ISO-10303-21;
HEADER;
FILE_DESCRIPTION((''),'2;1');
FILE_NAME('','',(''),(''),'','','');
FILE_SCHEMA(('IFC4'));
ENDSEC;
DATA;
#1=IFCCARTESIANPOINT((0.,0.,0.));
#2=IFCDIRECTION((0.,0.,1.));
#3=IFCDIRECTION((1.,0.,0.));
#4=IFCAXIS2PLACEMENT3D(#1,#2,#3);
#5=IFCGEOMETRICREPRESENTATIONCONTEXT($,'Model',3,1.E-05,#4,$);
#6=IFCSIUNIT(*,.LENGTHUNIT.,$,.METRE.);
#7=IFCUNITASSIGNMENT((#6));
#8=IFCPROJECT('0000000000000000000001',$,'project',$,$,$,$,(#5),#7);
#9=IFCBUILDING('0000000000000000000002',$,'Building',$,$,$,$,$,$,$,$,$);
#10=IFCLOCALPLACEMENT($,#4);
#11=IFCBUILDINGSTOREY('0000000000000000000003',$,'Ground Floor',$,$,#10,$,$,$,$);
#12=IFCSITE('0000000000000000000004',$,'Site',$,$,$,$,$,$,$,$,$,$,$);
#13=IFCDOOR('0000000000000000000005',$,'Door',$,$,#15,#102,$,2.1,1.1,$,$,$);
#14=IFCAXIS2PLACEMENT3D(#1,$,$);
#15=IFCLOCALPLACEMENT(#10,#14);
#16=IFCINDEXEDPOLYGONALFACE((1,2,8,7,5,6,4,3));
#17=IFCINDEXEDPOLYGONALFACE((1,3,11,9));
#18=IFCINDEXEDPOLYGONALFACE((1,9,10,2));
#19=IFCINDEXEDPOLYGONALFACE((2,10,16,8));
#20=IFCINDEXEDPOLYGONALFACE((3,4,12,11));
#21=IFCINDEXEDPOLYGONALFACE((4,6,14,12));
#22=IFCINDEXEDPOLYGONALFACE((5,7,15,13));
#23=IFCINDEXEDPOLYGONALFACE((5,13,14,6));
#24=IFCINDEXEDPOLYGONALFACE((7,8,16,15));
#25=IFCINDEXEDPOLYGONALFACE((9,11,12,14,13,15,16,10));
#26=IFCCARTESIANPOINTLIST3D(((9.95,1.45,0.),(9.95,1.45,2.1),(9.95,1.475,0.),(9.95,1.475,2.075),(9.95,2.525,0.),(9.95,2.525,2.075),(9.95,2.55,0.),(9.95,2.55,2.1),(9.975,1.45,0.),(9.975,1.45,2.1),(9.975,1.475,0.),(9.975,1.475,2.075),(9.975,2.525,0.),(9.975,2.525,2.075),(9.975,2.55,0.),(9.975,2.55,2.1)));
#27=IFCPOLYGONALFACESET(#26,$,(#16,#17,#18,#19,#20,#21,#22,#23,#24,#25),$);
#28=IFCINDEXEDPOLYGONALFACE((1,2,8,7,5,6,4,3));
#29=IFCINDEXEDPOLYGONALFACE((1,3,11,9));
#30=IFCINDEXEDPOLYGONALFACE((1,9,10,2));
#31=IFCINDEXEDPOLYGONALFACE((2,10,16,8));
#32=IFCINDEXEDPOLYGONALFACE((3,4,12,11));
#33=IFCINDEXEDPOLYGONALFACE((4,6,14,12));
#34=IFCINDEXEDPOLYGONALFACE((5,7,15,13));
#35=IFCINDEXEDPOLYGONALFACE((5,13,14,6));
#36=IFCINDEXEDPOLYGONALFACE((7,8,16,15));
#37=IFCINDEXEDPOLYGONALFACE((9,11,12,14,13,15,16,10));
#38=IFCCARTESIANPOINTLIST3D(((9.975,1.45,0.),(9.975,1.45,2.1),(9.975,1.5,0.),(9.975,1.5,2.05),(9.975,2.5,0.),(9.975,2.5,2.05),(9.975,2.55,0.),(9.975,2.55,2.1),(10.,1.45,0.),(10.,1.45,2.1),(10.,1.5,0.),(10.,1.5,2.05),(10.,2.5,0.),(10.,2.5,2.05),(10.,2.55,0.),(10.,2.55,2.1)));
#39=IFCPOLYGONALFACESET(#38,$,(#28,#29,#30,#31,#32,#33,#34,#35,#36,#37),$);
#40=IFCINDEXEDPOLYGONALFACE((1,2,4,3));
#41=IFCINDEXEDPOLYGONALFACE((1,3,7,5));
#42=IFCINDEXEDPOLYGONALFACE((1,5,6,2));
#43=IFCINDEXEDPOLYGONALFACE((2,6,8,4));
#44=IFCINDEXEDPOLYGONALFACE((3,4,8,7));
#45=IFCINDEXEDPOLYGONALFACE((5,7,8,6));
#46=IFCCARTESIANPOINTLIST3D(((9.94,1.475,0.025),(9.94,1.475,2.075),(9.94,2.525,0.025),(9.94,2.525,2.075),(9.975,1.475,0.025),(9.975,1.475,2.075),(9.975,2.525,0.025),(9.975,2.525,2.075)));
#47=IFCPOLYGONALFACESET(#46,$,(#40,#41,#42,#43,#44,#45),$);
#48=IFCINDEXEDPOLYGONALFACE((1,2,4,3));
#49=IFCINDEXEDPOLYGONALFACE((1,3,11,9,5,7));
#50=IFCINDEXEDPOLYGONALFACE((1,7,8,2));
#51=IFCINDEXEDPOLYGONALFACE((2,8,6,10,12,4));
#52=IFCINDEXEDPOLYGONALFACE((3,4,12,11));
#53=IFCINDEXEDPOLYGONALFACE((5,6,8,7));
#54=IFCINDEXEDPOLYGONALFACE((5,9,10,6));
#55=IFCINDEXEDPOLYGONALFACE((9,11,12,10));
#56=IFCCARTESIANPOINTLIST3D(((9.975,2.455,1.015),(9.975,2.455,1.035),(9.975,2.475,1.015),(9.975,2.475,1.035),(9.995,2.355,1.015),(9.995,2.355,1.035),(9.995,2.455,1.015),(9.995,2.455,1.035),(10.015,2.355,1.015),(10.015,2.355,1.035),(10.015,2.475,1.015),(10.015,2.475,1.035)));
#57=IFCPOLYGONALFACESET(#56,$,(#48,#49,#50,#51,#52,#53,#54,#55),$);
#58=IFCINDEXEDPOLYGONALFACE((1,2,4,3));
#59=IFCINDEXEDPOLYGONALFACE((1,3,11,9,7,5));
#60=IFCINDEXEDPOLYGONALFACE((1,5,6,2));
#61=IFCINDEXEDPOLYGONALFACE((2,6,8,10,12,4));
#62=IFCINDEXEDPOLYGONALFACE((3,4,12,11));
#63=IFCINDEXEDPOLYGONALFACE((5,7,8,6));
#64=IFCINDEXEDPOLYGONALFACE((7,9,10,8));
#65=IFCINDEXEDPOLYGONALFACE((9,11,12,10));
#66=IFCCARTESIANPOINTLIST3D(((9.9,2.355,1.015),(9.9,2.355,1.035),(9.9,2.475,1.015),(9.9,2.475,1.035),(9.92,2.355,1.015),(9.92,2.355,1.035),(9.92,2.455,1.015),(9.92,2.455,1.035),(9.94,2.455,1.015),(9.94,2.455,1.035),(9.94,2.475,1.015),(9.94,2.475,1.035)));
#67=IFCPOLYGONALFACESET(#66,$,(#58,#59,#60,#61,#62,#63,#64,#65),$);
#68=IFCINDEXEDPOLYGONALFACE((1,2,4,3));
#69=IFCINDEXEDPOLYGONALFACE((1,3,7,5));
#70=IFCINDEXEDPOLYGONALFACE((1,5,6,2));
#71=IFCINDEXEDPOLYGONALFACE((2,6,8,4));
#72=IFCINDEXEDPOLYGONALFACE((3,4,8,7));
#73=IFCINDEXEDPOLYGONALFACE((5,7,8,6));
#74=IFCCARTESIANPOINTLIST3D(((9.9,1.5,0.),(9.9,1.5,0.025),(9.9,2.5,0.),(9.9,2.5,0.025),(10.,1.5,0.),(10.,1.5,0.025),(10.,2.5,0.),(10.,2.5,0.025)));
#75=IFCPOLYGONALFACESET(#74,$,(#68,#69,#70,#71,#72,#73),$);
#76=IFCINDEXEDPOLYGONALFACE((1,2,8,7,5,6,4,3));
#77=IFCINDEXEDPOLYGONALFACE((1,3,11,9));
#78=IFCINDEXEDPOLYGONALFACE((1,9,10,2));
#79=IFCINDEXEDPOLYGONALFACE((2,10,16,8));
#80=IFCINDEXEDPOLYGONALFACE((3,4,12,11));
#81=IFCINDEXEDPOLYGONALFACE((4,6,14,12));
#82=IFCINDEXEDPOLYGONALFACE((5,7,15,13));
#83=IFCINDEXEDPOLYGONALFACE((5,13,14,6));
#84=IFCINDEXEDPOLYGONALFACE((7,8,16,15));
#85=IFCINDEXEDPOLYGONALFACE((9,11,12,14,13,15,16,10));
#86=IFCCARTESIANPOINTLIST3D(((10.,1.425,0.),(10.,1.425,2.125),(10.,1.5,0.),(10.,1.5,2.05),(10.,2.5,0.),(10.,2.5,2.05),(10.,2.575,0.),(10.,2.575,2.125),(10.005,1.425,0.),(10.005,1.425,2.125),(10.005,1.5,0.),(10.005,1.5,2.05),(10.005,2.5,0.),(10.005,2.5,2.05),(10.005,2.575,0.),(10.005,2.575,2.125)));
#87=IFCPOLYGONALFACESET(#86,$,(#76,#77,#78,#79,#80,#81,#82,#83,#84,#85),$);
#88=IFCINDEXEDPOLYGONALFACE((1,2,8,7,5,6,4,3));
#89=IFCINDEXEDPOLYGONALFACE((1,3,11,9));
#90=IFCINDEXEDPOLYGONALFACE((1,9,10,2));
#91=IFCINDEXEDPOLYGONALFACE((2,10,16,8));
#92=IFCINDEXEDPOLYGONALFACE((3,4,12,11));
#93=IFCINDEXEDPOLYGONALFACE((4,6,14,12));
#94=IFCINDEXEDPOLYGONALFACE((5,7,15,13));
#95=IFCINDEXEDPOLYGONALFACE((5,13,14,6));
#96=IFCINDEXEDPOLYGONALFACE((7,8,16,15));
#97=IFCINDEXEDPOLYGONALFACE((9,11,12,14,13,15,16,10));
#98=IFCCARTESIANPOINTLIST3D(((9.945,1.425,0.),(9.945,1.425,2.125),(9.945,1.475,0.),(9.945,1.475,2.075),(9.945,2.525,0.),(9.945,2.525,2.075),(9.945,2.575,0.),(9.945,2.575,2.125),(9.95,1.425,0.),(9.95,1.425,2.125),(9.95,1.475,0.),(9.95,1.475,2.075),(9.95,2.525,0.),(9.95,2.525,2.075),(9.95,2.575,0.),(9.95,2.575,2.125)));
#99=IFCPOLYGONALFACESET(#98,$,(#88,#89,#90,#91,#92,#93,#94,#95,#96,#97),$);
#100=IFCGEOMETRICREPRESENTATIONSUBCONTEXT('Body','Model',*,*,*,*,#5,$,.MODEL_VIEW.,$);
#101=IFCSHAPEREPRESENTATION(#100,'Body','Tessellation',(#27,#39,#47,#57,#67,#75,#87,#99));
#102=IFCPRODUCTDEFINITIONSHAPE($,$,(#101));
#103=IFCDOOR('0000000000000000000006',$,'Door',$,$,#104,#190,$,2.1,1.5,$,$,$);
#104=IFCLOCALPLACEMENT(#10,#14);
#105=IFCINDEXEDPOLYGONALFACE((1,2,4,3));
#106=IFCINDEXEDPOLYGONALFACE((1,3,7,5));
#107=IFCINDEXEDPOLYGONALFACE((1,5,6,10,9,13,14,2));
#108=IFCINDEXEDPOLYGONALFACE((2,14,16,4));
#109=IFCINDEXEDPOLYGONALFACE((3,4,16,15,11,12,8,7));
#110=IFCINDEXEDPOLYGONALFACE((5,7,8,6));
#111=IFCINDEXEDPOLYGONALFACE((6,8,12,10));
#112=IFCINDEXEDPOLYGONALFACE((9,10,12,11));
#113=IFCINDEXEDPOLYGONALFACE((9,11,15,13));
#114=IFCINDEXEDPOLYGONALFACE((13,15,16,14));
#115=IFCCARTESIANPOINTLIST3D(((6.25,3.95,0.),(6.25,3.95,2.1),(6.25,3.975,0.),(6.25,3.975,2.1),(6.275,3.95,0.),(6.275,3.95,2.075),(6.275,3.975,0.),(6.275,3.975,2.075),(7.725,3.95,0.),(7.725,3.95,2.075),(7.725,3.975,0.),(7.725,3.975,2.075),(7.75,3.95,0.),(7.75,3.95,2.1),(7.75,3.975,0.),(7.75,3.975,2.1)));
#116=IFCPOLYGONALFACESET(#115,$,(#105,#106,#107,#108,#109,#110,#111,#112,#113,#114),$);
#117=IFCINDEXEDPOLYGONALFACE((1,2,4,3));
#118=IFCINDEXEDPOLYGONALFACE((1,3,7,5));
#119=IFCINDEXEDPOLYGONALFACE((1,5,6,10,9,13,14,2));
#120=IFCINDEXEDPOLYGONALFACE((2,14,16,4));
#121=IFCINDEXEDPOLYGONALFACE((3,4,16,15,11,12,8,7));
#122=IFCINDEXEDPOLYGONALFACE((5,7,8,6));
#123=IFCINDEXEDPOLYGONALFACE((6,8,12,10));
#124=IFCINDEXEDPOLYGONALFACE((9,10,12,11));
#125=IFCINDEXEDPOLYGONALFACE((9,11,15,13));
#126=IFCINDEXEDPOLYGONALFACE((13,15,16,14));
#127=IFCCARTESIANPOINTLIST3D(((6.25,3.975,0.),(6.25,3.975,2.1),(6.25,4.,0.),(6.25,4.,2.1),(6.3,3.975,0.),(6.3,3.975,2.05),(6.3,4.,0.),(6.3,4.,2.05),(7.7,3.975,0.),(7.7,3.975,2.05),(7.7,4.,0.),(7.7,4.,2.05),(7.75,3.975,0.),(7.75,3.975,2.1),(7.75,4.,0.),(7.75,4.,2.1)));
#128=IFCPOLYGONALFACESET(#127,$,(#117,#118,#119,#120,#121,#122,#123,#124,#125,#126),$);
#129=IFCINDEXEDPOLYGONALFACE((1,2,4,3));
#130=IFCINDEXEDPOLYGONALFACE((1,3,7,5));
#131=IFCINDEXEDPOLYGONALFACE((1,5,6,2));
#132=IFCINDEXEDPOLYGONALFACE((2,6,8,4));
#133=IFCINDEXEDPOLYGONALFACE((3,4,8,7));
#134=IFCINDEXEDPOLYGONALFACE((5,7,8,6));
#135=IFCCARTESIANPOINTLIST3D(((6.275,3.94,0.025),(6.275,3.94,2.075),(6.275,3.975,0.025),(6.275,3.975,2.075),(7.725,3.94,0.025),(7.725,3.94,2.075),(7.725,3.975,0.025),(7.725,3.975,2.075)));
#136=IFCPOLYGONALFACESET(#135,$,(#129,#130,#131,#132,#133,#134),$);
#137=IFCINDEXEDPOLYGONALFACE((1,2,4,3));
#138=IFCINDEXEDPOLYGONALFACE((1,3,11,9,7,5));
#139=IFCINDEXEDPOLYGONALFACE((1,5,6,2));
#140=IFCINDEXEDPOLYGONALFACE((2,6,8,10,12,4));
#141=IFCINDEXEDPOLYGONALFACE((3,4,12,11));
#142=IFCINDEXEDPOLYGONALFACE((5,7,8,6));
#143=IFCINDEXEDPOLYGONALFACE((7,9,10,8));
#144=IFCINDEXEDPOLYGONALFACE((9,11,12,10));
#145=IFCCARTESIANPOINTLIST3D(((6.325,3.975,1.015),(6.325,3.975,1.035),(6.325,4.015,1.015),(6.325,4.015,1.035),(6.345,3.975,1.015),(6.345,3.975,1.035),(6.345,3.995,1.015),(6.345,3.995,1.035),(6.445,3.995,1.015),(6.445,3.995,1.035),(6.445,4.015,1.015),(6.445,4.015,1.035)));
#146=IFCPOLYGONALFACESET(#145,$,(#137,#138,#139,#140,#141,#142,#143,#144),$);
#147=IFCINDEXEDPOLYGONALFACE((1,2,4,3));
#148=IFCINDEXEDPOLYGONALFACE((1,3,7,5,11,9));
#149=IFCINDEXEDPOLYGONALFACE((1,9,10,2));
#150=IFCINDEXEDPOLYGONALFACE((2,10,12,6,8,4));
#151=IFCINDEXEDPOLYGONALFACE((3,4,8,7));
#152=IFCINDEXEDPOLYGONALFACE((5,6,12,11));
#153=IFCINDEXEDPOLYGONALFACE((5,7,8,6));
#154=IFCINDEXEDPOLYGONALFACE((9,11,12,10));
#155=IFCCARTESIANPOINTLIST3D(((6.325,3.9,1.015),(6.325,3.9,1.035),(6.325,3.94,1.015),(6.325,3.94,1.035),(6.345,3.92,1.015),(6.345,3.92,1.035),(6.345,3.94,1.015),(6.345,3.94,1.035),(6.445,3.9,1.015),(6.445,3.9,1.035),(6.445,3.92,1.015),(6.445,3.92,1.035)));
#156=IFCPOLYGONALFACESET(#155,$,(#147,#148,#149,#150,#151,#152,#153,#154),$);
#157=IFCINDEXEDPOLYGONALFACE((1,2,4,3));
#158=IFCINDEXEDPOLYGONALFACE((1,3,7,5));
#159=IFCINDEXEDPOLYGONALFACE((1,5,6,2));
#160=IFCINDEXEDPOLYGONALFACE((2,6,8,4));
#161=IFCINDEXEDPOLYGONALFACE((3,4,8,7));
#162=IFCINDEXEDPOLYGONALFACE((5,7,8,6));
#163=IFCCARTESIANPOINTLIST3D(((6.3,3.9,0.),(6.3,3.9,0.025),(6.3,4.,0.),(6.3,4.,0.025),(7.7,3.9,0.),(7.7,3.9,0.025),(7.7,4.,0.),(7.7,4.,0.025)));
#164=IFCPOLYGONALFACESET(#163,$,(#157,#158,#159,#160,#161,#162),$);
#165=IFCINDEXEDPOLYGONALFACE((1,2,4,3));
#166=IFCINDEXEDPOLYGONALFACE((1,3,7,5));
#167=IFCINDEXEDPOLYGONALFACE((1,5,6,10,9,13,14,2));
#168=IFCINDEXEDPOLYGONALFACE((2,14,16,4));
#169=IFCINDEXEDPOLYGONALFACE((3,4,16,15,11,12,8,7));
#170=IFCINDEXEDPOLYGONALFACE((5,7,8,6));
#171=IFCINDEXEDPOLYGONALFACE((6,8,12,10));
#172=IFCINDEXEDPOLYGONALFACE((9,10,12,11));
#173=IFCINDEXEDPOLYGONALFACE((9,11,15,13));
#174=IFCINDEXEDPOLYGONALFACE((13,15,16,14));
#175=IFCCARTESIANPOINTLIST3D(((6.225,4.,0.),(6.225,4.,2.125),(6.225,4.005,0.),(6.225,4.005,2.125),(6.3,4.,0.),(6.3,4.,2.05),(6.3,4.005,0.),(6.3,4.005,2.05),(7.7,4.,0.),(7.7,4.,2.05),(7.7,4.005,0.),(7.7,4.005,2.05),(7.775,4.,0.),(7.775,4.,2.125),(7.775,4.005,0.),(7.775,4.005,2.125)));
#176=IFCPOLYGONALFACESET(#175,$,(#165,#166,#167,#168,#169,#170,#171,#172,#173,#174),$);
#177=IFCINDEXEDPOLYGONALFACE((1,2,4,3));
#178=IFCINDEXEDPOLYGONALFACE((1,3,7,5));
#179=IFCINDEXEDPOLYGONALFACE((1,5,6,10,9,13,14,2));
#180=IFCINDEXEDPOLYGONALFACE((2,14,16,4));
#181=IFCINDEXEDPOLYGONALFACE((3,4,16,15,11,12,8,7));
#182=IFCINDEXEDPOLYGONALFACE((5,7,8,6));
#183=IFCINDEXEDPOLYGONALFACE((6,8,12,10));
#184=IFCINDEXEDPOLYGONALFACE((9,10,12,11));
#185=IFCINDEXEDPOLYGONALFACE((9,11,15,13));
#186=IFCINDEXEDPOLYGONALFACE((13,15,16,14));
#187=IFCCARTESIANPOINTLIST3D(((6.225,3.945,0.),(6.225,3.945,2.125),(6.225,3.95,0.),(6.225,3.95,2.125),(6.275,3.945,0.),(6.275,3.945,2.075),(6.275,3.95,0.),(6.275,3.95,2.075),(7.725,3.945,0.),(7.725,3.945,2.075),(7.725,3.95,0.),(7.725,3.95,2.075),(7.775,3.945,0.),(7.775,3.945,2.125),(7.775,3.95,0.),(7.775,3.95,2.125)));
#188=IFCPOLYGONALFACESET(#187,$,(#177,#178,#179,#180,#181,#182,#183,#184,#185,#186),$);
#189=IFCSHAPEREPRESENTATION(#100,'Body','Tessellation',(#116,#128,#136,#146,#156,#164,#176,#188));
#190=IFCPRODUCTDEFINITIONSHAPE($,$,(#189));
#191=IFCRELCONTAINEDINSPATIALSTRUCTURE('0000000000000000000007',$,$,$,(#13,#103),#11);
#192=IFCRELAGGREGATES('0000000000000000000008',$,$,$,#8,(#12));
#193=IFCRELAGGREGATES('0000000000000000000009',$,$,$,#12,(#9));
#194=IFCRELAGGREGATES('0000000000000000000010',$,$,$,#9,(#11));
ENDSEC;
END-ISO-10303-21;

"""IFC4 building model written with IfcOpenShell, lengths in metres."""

from ifc_helpers import new_model, si_unit, frame, origin_with_axes, place, context, subcontext, project, spatial, line, indexed_curve, outline, extrude, element, save


model = new_model("IFC4")

# Units and contexts
model_context = context("Model", 3, precision=1e-05, world=origin_with_axes())
body_context = subcontext(model_context, "Body", "Model", "MODEL_VIEW")
ifc_project = project(units=[si_unit("LENGTHUNIT", "METRE")], contexts=[model_context])

# Site, building, storey
site = spatial("IfcSite", under=ifc_project, Name="Site")
building = spatial("IfcBuilding", under=site, Name="Building")
storey_placement = place(None, origin_with_axes())
storey = spatial("IfcBuildingStorey", under=building, at=storey_placement, Name="Ground Floor")

# Doors
door_1_placement = place(storey_placement, frame((10.0, 1.45, 0.0), z_axis=(0.0, 0.0, 1.0), x_axis=(0.0, 1.0, 0.0)))
element("IfcDoor", 1, at=door_1_placement, inside=storey, Name="Door", OverallHeight=2.1, OverallWidth=1.1, context=body_context, shape_type="SweptSolid", body=[
    extrude(outline(indexed_curve([(0.0, 0.0), (0.0, 2.1), (1.1, 2.1), (1.1, 0.0), (1.075, 0.0), (1.075, 2.075), (0.025, 2.075), (0.025, 0.0)], segments=[line(1, 2, 3, 4, 5, 6, 7, 8, 1)])), frame((0.0, 0.025, 0.0), z_axis=(0.0, -1.0, 0.0), x_axis=(1.0, 0.0, 0.0)), (0.0, 0.0, -1.0), 0.025),
    extrude(outline(indexed_curve([(0.0, 0.0), (0.0, 2.1), (1.1, 2.1), (1.1, 0.0), (1.05, 0.0), (1.05, 2.05), (0.05, 2.05), (0.05, 0.0)], segments=[line(1, 2, 3, 4, 5, 6, 7, 8, 1)])), frame((0.0, 0.0, 0.0), z_axis=(0.0, -1.0, 0.0), x_axis=(1.0, 0.0, 0.0)), (0.0, 0.0, -1.0), 0.025),
    extrude(outline(indexed_curve([(0.0, 0.0), (1.05, 0.0), (1.05, 0.035), (0.0, 0.035)], segments=[line(1, 2, 3, 4, 1)])), frame((0.025, 0.025, 0.025), z_axis=(0.0, 0.0, 1.0), x_axis=(1.0, 0.0, 0.0)), (0.0, 0.0, 1.0), 2.05),
    extrude(outline(indexed_curve([(0.0, 0.0), (0.0, -0.04), (-0.12, -0.04), (-0.12, -0.02), (-0.02, -0.02), (-0.02, 0.0)], segments=[line(1, 2, 3, 4, 5, 6, 1)])), frame((1.025, 0.025, 1.015), z_axis=(0.0, 0.0, 1.0), x_axis=(1.0, 0.0, 0.0)), (0.0, 0.0, 1.0), 0.02),
    extrude(outline(indexed_curve([(0.0, 0.0), (0.0, 0.04), (-0.12, 0.04), (-0.12, 0.02), (-0.02, 0.02), (-0.02, 0.0)], segments=[line(1, 2, 3, 4, 5, 6, 1)])), frame((1.025, 0.06, 1.015), z_axis=(0.0, 0.0, 1.0), x_axis=(1.0, 0.0, 0.0)), (0.0, 0.0, 1.0), 0.02),
    extrude(outline(indexed_curve([(0.0, 0.0), (1.0, 0.0), (1.0, 0.1), (0.0, 0.1)], segments=[line(1, 2, 3, 4, 1)])), frame((0.05, 0.0, 0.0), z_axis=(0.0, 0.0, 1.0), x_axis=(1.0, 0.0, 0.0)), (0.0, 0.0, 1.0), 0.025),
    extrude(outline(indexed_curve([(0.0, 0.0), (0.0, 2.125), (1.15, 2.125), (1.15, 0.0), (1.075, 0.0), (1.075, 2.05), (0.075, 2.05), (0.075, 0.0)], segments=[line(1, 2, 3, 4, 5, 6, 7, 8, 1)])), frame((-0.025, -0.005, 0.0), z_axis=(0.0, -1.0, 0.0), x_axis=(1.0, 0.0, 0.0)), (0.0, 0.0, -1.0), 0.005),
    extrude(outline(indexed_curve([(0.0, 0.0), (0.0, 2.125), (1.15, 2.125), (1.15, 0.0), (1.1, 0.0), (1.1, 2.075), (0.05, 2.075), (0.05, 0.0)], segments=[line(1, 2, 3, 4, 5, 6, 7, 8, 1)])), frame((-0.025, 0.05, 0.0), z_axis=(0.0, -1.0, 0.0), x_axis=(1.0, 0.0, 0.0)), (0.0, 0.0, -1.0), 0.005),
])
door_2_placement = place(storey_placement, frame((7.75, 4.0, 0.0), z_axis=(0.0, 0.0, 1.0), x_axis=(-1.0, 0.0, 0.0)))
element("IfcDoor", 2, at=door_2_placement, inside=storey, Name="Door", OverallHeight=2.1, OverallWidth=1.5, context=body_context, shape_type="SweptSolid", body=[
    extrude(outline(indexed_curve([(0.0, 0.0), (0.0, 2.1), (1.5, 2.1), (1.5, 0.0), (1.475, 0.0), (1.475, 2.075), (0.025, 2.075), (0.025, 0.0)], segments=[line(1, 2, 3, 4, 5, 6, 7, 8, 1)])), frame((0.0, 0.025, 0.0), z_axis=(0.0, -1.0, 0.0), x_axis=(1.0, 0.0, 0.0)), (0.0, 0.0, -1.0), 0.025),
    extrude(outline(indexed_curve([(0.0, 0.0), (0.0, 2.1), (1.5, 2.1), (1.5, 0.0), (1.45, 0.0), (1.45, 2.05), (0.05, 2.05), (0.05, 0.0)], segments=[line(1, 2, 3, 4, 5, 6, 7, 8, 1)])), frame((0.0, 0.0, 0.0), z_axis=(0.0, -1.0, 0.0), x_axis=(1.0, 0.0, 0.0)), (0.0, 0.0, -1.0), 0.025),
    extrude(outline(indexed_curve([(0.0, 0.0), (1.45, 0.0), (1.45, 0.035), (0.0, 0.035)], segments=[line(1, 2, 3, 4, 1)])), frame((0.025, 0.025, 0.025), z_axis=(0.0, 0.0, 1.0), x_axis=(1.0, 0.0, 0.0)), (0.0, 0.0, 1.0), 2.05),
    extrude(outline(indexed_curve([(0.0, 0.0), (0.0, -0.04), (-0.12, -0.04), (-0.12, -0.02), (-0.02, -0.02), (-0.02, 0.0)], segments=[line(1, 2, 3, 4, 5, 6, 1)])), frame((1.425, 0.025, 1.015), z_axis=(0.0, 0.0, 1.0), x_axis=(1.0, 0.0, 0.0)), (0.0, 0.0, 1.0), 0.02),
    extrude(outline(indexed_curve([(0.0, 0.0), (0.0, 0.04), (-0.12, 0.04), (-0.12, 0.02), (-0.02, 0.02), (-0.02, 0.0)], segments=[line(1, 2, 3, 4, 5, 6, 1)])), frame((1.425, 0.06, 1.015), z_axis=(0.0, 0.0, 1.0), x_axis=(1.0, 0.0, 0.0)), (0.0, 0.0, 1.0), 0.02),
    extrude(outline(indexed_curve([(0.0, 0.0), (1.4, 0.0), (1.4, 0.1), (0.0, 0.1)], segments=[line(1, 2, 3, 4, 1)])), frame((0.05, 0.0, 0.0), z_axis=(0.0, 0.0, 1.0), x_axis=(1.0, 0.0, 0.0)), (0.0, 0.0, 1.0), 0.025),
    extrude(outline(indexed_curve([(0.0, 0.0), (0.0, 2.125), (1.55, 2.125), (1.55, 0.0), (1.475, 0.0), (1.475, 2.05), (0.075, 2.05), (0.075, 0.0)], segments=[line(1, 2, 3, 4, 5, 6, 7, 8, 1)])), frame((-0.025, -0.005, 0.0), z_axis=(0.0, -1.0, 0.0), x_axis=(1.0, 0.0, 0.0)), (0.0, 0.0, -1.0), 0.005),
    extrude(outline(indexed_curve([(0.0, 0.0), (0.0, 2.125), (1.55, 2.125), (1.55, 0.0), (1.5, 0.0), (1.5, 2.075), (0.05, 2.075), (0.05, 0.0)], segments=[line(1, 2, 3, 4, 5, 6, 7, 8, 1)])), frame((-0.025, 0.05, 0.0), z_axis=(0.0, -1.0, 0.0), x_axis=(1.0, 0.0, 0.0)), (0.0, 0.0, -1.0), 0.005),
])

save(model, "model.ifc")
